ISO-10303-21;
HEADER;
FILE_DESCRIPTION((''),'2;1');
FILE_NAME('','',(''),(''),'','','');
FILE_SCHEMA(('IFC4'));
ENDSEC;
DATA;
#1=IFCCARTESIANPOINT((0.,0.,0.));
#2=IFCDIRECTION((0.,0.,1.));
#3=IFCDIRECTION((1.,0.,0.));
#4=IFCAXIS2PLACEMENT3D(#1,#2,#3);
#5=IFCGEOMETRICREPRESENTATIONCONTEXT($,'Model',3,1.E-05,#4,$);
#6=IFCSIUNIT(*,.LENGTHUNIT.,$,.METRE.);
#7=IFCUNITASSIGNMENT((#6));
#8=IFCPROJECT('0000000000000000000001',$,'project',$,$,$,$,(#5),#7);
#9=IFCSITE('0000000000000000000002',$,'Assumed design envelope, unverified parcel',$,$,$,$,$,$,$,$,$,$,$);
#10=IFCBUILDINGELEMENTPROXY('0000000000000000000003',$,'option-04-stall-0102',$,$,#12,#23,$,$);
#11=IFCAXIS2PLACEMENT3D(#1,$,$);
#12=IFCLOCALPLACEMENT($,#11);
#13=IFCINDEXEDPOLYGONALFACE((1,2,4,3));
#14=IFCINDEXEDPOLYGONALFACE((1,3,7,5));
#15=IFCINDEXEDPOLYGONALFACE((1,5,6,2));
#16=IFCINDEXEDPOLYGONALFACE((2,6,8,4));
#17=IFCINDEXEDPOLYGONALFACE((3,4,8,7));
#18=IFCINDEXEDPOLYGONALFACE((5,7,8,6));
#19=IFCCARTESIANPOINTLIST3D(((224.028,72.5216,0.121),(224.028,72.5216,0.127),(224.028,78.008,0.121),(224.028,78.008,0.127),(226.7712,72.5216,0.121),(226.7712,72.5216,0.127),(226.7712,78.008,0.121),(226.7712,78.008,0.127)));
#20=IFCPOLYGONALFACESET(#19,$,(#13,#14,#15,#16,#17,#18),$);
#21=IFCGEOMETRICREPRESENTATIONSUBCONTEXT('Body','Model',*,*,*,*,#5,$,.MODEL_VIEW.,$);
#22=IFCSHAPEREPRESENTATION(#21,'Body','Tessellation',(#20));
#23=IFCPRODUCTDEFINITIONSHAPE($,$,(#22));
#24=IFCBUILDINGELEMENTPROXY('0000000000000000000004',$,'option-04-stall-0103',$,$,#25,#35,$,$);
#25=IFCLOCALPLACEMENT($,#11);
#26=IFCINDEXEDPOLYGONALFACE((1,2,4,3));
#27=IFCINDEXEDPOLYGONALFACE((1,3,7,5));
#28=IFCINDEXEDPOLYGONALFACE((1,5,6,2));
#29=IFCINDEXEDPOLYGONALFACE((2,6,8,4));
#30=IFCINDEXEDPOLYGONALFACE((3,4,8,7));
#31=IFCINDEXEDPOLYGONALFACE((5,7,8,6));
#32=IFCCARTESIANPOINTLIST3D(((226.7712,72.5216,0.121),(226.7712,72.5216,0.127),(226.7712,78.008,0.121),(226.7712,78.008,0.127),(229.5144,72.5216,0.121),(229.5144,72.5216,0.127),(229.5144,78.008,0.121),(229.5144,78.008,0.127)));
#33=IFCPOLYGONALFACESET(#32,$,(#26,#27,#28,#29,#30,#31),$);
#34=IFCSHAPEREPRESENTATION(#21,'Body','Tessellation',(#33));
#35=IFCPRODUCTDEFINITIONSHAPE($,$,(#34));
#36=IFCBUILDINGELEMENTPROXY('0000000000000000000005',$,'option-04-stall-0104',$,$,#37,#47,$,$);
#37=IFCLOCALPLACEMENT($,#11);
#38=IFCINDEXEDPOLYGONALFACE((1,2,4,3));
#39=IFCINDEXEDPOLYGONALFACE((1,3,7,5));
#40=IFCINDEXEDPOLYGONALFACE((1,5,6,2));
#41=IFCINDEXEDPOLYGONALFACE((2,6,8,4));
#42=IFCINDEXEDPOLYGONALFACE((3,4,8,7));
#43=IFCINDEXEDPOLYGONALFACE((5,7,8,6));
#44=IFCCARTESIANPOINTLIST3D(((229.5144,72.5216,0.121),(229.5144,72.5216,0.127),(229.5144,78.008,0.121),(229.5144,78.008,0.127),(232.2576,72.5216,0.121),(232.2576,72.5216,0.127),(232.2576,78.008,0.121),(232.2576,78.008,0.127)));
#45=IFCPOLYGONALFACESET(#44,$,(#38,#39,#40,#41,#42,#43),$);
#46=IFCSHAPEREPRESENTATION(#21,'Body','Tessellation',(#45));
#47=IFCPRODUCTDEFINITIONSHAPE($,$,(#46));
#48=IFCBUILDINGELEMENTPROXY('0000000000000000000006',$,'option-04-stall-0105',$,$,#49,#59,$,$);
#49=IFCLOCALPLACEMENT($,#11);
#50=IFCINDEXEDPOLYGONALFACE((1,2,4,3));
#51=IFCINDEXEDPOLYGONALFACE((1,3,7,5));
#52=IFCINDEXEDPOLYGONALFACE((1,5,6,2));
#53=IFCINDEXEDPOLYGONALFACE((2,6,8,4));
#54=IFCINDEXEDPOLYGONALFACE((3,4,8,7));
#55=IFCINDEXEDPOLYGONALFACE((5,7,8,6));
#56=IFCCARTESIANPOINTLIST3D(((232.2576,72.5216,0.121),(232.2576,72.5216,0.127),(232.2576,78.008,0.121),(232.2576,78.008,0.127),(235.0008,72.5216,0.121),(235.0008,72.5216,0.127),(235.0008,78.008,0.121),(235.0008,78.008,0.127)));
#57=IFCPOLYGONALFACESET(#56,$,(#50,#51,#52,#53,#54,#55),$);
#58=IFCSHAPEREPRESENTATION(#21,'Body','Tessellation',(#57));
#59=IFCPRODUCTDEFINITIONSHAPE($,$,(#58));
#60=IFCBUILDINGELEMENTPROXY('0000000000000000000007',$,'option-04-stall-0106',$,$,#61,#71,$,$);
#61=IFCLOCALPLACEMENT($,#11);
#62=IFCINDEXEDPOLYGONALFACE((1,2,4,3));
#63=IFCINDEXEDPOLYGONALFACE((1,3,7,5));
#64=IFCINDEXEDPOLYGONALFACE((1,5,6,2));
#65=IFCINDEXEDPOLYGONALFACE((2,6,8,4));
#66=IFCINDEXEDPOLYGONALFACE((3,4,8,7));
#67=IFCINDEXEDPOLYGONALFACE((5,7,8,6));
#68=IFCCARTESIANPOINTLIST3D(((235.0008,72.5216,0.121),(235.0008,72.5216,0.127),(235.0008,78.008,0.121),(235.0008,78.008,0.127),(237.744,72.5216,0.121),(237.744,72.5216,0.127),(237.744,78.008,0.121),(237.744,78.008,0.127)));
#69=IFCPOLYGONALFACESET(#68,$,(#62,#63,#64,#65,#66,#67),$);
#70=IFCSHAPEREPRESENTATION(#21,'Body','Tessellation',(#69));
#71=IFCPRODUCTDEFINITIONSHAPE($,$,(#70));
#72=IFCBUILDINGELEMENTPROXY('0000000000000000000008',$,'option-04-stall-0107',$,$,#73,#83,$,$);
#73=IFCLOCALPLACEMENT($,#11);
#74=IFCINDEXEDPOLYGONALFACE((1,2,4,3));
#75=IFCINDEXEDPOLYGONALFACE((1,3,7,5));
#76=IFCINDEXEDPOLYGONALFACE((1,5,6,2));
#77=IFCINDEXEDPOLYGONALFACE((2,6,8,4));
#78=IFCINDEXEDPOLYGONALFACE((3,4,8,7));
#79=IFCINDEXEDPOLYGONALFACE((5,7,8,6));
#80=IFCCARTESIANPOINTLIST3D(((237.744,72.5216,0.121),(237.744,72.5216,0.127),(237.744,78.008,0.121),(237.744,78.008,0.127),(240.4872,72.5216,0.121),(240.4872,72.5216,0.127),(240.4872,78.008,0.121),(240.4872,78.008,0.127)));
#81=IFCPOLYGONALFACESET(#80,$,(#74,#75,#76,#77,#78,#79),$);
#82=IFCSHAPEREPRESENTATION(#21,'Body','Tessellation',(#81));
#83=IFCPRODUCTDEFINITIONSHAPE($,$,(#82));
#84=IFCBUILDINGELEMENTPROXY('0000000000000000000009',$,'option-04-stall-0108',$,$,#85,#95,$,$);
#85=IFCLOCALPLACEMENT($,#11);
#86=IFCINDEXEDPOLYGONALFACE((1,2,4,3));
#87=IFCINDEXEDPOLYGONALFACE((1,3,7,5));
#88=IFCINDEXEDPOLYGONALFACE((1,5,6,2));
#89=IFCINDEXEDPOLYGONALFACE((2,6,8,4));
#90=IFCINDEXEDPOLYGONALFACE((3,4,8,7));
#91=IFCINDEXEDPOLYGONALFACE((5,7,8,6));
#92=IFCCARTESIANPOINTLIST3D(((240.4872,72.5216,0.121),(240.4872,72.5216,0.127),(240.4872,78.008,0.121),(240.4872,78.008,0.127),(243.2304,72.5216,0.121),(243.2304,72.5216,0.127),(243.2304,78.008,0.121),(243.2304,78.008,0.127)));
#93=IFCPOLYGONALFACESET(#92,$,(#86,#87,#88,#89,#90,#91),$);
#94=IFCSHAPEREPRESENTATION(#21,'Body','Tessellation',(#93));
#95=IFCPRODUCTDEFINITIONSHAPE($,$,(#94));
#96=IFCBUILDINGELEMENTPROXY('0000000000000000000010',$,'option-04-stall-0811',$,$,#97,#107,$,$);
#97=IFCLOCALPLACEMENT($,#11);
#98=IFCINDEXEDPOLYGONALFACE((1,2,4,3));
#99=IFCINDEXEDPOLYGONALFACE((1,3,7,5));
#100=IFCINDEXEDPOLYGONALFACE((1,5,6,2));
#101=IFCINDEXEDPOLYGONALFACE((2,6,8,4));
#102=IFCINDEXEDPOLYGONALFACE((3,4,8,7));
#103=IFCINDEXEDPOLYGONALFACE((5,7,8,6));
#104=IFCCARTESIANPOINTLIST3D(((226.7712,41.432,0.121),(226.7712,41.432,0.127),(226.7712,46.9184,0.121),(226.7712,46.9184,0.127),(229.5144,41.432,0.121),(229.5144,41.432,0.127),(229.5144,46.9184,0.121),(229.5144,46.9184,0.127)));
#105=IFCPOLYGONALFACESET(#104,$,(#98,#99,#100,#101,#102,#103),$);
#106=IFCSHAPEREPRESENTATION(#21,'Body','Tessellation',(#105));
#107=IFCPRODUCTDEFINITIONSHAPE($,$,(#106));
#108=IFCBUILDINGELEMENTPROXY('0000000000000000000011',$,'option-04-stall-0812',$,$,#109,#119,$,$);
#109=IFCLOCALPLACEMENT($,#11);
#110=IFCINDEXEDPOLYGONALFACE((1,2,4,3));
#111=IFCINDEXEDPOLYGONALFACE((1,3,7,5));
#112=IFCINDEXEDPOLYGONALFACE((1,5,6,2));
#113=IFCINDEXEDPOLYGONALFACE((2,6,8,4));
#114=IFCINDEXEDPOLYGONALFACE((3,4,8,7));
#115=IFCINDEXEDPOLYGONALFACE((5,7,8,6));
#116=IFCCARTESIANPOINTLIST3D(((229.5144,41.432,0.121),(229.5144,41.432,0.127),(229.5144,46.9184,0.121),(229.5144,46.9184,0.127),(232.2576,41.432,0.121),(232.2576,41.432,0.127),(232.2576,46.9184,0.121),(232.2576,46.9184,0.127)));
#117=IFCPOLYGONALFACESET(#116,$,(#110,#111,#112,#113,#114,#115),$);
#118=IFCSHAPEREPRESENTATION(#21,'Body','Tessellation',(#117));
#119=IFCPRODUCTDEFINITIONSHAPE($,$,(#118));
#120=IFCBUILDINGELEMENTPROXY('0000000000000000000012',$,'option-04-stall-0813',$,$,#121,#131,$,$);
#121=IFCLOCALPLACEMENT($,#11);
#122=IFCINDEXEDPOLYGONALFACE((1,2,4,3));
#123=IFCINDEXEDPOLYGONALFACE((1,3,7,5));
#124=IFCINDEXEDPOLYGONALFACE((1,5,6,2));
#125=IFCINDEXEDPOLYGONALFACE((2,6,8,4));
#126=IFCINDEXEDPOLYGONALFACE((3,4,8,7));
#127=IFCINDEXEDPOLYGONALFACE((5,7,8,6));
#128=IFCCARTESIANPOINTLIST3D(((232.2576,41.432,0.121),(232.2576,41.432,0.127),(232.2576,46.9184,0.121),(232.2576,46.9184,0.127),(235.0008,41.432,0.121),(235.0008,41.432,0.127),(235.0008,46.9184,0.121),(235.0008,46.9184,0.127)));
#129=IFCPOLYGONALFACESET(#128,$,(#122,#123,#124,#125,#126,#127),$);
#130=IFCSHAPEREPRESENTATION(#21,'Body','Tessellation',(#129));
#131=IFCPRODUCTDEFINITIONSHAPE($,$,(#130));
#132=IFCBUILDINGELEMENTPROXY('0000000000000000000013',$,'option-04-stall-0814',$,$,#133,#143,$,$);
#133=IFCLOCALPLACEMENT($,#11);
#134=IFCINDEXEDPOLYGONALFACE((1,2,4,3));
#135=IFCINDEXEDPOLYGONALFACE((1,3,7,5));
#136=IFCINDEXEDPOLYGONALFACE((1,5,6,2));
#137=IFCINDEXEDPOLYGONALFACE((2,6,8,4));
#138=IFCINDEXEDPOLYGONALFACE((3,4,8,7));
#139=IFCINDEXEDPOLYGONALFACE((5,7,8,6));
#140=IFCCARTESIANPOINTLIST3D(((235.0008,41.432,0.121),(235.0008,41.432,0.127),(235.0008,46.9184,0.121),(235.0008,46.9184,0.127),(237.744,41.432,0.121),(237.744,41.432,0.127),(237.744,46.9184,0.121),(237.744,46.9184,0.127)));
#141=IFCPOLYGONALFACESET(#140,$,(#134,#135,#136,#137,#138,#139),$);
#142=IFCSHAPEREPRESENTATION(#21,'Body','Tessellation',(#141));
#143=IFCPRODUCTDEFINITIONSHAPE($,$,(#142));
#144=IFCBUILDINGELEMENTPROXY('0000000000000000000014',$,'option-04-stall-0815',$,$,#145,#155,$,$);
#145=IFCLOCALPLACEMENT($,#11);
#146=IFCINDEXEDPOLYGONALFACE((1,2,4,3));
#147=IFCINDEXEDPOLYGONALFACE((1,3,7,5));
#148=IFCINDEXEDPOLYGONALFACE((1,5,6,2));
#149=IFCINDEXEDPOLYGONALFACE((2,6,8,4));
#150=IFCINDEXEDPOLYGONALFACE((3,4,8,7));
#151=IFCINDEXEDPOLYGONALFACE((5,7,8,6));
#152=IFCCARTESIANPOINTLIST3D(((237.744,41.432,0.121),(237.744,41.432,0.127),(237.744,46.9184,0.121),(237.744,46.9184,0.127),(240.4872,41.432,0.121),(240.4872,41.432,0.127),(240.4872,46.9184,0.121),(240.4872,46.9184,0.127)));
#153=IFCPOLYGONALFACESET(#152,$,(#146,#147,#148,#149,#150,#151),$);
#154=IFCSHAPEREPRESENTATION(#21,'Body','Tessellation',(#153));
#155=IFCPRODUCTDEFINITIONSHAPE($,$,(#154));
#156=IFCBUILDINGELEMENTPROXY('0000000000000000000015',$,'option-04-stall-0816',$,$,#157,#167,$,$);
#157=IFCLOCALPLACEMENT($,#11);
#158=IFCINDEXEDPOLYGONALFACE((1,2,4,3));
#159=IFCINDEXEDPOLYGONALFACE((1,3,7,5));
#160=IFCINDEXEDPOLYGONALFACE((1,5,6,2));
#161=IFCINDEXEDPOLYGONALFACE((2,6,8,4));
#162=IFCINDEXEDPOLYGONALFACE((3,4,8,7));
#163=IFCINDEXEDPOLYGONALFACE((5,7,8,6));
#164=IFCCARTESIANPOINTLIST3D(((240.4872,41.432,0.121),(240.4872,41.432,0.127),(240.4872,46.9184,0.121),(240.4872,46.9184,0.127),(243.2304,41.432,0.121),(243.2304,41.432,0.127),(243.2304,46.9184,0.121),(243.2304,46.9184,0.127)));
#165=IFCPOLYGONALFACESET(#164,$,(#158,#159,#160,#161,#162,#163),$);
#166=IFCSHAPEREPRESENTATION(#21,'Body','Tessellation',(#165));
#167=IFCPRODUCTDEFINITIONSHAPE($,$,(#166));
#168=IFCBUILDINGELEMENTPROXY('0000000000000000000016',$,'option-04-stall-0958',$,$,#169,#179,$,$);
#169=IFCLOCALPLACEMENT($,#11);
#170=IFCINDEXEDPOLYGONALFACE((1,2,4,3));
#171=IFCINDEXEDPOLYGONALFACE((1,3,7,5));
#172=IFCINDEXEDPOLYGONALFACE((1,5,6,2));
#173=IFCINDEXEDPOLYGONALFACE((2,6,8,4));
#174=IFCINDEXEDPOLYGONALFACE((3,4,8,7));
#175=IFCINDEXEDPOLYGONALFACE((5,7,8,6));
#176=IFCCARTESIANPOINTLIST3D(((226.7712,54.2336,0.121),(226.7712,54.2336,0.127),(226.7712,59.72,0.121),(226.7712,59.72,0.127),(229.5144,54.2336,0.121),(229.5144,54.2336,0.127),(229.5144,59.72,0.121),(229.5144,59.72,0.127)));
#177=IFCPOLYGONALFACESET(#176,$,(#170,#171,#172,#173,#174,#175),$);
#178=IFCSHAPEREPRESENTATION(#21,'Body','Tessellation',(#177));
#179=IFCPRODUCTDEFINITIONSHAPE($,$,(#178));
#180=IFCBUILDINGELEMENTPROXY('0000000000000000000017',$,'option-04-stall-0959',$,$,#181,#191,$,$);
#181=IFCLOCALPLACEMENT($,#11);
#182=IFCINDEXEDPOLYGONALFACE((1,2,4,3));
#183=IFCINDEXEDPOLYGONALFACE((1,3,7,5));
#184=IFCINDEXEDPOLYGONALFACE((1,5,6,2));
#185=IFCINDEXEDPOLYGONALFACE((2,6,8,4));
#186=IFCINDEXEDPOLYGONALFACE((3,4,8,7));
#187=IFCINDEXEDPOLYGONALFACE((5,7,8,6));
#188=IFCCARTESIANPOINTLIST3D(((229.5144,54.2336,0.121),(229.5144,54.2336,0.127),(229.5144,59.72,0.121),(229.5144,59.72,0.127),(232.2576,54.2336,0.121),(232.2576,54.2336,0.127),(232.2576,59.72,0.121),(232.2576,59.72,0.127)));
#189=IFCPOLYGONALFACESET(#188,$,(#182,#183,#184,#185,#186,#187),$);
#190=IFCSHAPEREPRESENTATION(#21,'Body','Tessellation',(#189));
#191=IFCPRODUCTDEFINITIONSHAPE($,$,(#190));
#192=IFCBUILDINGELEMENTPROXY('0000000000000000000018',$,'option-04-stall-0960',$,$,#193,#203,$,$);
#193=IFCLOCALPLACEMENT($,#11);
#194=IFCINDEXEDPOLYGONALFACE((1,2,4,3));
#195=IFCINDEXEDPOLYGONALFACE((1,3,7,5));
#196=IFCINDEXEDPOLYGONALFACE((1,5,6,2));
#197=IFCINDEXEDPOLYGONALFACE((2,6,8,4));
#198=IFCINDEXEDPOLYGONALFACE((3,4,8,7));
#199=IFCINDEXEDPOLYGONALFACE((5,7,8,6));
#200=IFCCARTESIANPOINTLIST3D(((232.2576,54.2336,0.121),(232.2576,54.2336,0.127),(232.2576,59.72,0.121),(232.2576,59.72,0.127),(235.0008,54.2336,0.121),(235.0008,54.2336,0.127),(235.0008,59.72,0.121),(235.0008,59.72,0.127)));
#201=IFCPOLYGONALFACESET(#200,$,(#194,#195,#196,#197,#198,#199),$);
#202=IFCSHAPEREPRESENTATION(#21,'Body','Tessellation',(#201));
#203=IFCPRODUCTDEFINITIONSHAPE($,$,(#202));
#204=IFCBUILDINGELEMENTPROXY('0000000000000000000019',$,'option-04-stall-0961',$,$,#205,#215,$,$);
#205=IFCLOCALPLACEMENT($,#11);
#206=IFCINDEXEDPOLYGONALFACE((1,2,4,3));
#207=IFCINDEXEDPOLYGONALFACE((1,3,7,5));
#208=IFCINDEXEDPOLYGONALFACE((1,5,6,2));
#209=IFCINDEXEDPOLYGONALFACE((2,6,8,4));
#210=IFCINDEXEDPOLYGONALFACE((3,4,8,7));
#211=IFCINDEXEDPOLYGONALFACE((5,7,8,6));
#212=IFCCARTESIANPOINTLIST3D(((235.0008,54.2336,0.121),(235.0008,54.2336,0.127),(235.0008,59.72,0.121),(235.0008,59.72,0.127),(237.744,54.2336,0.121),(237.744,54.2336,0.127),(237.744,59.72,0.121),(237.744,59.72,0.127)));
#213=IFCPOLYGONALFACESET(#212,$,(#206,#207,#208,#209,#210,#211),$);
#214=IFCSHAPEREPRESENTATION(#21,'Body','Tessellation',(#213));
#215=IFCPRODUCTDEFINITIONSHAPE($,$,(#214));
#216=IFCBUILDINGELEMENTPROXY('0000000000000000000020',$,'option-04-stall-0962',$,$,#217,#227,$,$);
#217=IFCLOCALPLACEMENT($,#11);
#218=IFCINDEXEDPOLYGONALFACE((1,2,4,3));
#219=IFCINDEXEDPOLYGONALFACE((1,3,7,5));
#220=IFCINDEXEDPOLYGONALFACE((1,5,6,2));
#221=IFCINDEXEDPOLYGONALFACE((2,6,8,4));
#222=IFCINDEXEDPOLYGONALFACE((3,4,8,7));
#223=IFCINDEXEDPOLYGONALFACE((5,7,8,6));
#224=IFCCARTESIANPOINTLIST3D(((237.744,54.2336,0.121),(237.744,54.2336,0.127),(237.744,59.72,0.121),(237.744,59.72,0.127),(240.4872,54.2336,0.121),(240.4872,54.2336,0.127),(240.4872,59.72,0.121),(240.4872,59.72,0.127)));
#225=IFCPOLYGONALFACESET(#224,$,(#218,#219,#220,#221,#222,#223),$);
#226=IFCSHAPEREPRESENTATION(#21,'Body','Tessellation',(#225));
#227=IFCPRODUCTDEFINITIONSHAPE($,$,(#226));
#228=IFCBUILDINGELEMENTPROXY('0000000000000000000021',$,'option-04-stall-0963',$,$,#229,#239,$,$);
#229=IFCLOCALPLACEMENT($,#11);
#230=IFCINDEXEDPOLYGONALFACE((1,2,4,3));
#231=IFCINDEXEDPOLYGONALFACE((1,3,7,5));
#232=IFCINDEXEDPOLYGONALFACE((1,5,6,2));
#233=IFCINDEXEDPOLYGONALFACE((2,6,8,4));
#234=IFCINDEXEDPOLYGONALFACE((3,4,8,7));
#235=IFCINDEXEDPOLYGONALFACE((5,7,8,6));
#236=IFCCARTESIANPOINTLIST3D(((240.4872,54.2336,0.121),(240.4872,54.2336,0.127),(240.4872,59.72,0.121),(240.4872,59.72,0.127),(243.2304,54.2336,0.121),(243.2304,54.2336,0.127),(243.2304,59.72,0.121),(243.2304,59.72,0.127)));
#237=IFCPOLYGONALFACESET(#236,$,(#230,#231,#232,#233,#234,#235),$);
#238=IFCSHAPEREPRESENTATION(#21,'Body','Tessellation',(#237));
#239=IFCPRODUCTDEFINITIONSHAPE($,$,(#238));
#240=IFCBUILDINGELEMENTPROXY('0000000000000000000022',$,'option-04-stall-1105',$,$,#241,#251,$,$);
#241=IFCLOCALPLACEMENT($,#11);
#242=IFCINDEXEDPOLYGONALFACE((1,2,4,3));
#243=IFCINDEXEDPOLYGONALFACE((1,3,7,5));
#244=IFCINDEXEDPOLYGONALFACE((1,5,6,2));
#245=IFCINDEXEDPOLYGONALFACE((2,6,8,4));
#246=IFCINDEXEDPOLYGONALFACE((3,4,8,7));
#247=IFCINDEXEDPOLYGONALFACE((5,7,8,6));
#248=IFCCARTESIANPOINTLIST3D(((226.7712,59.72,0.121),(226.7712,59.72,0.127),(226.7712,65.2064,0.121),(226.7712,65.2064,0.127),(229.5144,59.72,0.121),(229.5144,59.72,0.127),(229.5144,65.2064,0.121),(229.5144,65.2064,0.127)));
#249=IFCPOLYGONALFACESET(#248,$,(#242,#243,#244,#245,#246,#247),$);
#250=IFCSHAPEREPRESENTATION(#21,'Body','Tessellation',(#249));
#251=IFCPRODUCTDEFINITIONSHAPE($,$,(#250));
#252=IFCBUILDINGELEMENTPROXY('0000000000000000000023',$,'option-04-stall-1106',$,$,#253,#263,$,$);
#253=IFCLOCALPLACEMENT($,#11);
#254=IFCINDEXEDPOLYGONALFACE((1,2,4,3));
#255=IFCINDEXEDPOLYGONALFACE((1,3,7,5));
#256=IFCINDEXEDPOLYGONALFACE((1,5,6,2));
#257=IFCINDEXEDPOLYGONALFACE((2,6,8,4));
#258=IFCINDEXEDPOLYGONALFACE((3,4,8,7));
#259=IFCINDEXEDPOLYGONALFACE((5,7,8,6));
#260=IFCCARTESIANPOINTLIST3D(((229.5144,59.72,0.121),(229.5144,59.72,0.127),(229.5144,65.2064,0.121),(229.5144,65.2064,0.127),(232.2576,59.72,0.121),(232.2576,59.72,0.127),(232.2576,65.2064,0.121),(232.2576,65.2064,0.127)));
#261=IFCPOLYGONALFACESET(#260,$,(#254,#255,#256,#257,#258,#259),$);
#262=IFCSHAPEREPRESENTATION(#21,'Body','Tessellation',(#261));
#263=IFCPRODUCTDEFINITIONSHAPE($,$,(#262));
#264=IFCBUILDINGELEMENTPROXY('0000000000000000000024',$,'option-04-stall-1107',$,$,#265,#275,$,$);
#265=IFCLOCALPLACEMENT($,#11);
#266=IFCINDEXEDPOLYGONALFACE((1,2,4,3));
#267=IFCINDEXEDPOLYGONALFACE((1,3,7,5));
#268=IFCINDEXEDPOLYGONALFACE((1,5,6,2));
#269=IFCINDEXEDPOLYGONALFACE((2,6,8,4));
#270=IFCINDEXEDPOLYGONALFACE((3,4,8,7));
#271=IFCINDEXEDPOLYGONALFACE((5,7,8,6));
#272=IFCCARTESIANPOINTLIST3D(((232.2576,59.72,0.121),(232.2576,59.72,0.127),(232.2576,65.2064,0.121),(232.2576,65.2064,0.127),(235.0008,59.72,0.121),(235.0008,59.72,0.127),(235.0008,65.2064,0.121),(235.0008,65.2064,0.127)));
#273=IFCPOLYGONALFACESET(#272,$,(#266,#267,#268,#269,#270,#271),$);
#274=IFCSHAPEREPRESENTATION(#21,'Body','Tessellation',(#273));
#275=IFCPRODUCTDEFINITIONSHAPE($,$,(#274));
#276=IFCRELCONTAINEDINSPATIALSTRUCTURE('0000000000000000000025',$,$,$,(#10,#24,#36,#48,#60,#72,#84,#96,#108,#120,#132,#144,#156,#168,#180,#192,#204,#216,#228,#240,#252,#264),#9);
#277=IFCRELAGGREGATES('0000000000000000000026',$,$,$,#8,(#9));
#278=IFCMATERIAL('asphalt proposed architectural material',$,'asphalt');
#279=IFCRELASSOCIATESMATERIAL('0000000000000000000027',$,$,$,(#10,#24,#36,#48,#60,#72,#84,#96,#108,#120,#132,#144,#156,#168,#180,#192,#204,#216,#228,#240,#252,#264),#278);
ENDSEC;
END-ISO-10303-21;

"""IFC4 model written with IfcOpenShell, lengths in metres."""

from ifc_helpers import new_model, si_unit, frame, origin_with_axes, place, context, subcontext, project, spatial, rectangle, extrude, material, element, save


model = new_model("IFC4")

# Units and contexts
model_context = context("Model", 3, precision=1e-05, world=origin_with_axes())
body_context = subcontext(model_context, "Body", "Model", "MODEL_VIEW")
ifc_project = project(units=[si_unit("LENGTHUNIT", "METRE")], contexts=[model_context])

# Site
site = spatial("IfcSite", under=ifc_project, Name="Assumed design envelope, unverified parcel")

# Building element proxies
ifc_material = material(Name="asphalt proposed architectural material", Category="asphalt")
for number, where, z_axis, x_axis, name in (
    (1, (225.3996, 75.2648, 0.121), (0.0, 0.0, 1.0), (1.0, 0.0, 0.0), "option-04-stall-0102"),
    (2, (228.1428, 75.2648, 0.121), (0.0, 0.0, 1.0), (1.0, 0.0, 0.0), "option-04-stall-0103"),
    (3, (230.886, 75.2648, 0.121), (0.0, 0.0, 1.0), (1.0, 0.0, 0.0), "option-04-stall-0104"),
    (4, (233.6292, 75.2648, 0.121), (0.0, 0.0, 1.0), (1.0, 0.0, 0.0), "option-04-stall-0105"),
    (5, (236.3724, 75.2648, 0.121), (0.0, 0.0, 1.0), (1.0, 0.0, 0.0), "option-04-stall-0106"),
    (6, (239.1156, 75.2648, 0.121), (0.0, 0.0, 1.0), (1.0, 0.0, 0.0), "option-04-stall-0107"),
    (7, (241.8588, 75.2648, 0.121), (0.0, 0.0, 1.0), (1.0, 0.0, 0.0), "option-04-stall-0108"),
    (8, (228.1428, 44.1752, 0.121), (0.0, 0.0, 1.0), (1.0, 0.0, 0.0), "option-04-stall-0811"),
    (9, (230.886, 44.1752, 0.121), (0.0, 0.0, 1.0), (1.0, 0.0, 0.0), "option-04-stall-0812"),
    (10, (233.6292, 44.1752, 0.121), (0.0, 0.0, 1.0), (1.0, 0.0, 0.0), "option-04-stall-0813"),
    (11, (236.3724, 44.1752, 0.121), (0.0, 0.0, 1.0), (1.0, 0.0, 0.0), "option-04-stall-0814"),
    (12, (239.1156, 44.1752, 0.121), (0.0, 0.0, 1.0), (1.0, 0.0, 0.0), "option-04-stall-0815"),
    (13, (241.8588, 44.1752, 0.121), (0.0, 0.0, 1.0), (1.0, 0.0, 0.0), "option-04-stall-0816"),
    (14, (228.1428, 56.9768, 0.121), (0.0, 0.0, 1.0), (1.0, 0.0, 0.0), "option-04-stall-0958"),
    (15, (230.886, 56.9768, 0.121), (0.0, 0.0, 1.0), (1.0, 0.0, 0.0), "option-04-stall-0959"),
    (16, (233.6292, 56.9768, 0.121), (0.0, 0.0, 1.0), (1.0, 0.0, 0.0), "option-04-stall-0960"),
    (17, (236.3724, 56.9768, 0.121), (0.0, 0.0, 1.0), (1.0, 0.0, 0.0), "option-04-stall-0961"),
    (18, (239.1156, 56.9768, 0.121), (0.0, 0.0, 1.0), (1.0, 0.0, 0.0), "option-04-stall-0962"),
    (19, (241.8588, 56.9768, 0.121), (0.0, 0.0, 1.0), (1.0, 0.0, 0.0), "option-04-stall-0963"),
    (20, (228.1428, 62.4632, 0.121), (0.0, 0.0, 1.0), (1.0, 0.0, 0.0), "option-04-stall-1105"),
    (21, (230.886, 62.4632, 0.121), (0.0, 0.0, 1.0), (1.0, 0.0, 0.0), "option-04-stall-1106"),
    (22, (233.6292, 62.4632, 0.121), (0.0, 0.0, 1.0), (1.0, 0.0, 0.0), "option-04-stall-1107"),
):
    element("IfcBuildingElementProxy", number, at=place(None, frame(where, z_axis=z_axis, x_axis=x_axis)), inside=site, material=ifc_material, Name=name, context=body_context, shape_type="SweptSolid", body=[
        extrude(rectangle(XDim=2.7432, YDim=5.4864), origin_with_axes(), (0.0, 0.0, 1.0), 0.006),
    ])

save(model, "model.ifc")
